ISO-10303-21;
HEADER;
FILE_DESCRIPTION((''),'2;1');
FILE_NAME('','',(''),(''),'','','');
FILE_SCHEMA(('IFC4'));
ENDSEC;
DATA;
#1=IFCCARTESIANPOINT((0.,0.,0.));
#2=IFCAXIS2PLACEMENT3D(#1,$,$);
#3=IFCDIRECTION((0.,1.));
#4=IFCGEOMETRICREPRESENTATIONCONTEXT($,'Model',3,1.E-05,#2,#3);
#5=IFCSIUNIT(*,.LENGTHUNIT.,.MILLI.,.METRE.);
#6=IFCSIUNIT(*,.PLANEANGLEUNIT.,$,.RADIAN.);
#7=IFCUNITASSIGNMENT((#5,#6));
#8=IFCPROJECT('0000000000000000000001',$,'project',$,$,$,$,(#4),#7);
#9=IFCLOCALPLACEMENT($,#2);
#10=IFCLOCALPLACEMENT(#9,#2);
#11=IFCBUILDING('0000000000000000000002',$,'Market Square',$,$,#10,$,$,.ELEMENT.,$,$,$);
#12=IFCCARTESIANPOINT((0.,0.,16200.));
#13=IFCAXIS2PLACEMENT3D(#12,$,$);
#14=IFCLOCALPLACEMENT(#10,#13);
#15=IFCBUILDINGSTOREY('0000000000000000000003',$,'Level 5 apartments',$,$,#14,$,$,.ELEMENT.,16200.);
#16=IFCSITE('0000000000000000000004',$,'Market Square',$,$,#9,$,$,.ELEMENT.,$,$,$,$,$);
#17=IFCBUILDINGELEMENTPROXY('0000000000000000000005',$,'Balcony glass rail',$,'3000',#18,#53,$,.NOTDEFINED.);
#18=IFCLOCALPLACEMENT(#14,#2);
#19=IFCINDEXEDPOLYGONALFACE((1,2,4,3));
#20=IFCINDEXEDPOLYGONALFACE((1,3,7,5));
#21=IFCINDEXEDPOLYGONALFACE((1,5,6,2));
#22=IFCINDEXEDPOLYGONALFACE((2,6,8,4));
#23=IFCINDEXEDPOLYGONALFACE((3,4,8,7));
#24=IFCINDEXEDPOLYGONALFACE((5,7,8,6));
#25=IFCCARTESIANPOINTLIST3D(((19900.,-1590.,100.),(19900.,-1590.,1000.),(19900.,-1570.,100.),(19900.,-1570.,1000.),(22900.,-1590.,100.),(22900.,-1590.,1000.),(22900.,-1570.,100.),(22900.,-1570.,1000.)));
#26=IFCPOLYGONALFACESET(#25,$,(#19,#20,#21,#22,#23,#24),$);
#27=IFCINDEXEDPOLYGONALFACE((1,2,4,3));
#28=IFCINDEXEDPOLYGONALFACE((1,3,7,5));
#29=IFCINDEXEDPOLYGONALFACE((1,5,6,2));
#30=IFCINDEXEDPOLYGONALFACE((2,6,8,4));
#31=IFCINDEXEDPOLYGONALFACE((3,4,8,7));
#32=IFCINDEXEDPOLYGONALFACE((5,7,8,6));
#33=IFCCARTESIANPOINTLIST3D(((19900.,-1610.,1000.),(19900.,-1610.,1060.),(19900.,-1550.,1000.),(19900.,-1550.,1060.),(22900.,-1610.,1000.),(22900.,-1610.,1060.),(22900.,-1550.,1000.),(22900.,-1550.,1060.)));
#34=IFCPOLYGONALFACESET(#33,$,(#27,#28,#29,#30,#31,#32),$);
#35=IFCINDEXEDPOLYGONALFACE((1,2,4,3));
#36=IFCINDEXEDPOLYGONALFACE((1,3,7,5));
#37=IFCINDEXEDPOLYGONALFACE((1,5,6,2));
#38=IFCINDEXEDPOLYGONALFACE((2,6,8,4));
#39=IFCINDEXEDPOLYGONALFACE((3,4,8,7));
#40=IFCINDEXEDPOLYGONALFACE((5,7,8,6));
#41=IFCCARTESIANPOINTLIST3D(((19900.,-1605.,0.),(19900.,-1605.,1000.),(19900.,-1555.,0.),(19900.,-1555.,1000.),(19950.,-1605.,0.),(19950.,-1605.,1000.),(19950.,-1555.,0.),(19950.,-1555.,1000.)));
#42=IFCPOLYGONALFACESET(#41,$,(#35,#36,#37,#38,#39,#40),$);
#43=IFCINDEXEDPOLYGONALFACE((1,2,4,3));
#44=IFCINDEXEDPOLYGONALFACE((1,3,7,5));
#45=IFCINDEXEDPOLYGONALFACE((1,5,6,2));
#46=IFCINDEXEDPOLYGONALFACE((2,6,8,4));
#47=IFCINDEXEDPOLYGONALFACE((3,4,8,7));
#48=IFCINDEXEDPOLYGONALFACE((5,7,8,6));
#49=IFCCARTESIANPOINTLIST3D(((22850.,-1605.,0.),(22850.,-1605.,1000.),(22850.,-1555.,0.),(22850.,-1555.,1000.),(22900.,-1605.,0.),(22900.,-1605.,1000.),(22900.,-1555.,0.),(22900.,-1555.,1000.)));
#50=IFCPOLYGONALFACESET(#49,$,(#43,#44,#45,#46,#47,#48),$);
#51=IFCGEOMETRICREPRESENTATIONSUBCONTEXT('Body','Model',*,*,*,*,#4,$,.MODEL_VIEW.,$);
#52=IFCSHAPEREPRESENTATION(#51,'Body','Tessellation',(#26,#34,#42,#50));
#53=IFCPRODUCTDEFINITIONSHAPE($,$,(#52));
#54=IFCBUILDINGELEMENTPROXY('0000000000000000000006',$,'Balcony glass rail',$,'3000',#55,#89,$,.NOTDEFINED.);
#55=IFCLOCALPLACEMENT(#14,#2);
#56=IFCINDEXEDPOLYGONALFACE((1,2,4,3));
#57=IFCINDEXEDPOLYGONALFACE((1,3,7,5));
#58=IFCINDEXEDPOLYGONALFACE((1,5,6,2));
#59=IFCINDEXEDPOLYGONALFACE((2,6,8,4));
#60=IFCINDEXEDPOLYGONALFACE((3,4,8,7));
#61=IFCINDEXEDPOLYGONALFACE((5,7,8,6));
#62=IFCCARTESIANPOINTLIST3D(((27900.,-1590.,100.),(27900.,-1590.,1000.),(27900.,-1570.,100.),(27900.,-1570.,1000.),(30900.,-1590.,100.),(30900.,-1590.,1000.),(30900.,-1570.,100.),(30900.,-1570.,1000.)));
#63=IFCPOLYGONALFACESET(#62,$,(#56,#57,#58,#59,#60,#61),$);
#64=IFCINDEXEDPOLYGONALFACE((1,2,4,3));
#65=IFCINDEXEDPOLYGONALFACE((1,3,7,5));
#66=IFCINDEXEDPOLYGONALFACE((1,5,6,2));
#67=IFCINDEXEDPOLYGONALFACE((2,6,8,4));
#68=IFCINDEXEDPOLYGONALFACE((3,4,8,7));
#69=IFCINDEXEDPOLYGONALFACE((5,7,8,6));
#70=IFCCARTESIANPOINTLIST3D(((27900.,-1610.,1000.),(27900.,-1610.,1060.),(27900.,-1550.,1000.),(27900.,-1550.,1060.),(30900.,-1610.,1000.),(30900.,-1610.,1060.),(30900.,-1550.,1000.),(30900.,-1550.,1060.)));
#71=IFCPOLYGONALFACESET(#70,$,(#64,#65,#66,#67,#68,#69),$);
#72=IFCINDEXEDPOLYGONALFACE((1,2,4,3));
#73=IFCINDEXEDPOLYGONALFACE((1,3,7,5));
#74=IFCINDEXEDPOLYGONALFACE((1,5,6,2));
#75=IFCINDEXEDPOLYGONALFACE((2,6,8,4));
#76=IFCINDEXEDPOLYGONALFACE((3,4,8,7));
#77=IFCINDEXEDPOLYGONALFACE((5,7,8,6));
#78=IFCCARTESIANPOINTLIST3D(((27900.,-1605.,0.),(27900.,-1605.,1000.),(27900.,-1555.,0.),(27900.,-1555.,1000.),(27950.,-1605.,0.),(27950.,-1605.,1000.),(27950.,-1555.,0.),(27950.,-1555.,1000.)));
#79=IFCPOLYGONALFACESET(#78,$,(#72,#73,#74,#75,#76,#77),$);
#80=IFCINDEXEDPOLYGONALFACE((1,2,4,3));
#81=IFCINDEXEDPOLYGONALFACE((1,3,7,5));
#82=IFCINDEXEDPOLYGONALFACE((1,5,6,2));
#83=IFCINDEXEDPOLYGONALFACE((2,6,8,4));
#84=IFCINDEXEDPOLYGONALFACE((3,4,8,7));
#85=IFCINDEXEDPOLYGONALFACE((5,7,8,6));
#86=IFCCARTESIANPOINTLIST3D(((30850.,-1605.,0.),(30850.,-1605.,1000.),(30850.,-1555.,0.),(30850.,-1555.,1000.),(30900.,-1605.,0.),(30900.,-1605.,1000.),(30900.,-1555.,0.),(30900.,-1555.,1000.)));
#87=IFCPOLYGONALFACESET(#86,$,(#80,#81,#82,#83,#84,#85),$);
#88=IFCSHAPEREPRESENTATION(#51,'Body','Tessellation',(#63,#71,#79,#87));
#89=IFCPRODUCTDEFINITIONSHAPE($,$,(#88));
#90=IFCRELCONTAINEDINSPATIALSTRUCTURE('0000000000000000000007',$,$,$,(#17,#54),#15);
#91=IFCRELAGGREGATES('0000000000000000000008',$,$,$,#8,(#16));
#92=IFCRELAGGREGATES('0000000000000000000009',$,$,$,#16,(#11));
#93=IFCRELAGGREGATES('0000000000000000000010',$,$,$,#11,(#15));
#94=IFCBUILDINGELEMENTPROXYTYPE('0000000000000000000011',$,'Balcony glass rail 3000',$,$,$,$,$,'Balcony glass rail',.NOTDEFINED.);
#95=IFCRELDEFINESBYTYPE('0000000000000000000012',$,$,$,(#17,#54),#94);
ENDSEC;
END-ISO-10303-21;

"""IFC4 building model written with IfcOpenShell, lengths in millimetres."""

from ifc_helpers import new_model, si_unit, direction, frame, origin, place, context, subcontext, project, spatial, polyline, outline, extrude, source, transform, mapped, type_object, type_shapes, element, save


model = new_model("IFC4")

# Units and contexts
model_context = context("Model", 3, precision=1e-05, world=origin(), true_north=direction((0.0, 1.0)))
body_context = subcontext(model_context, "Body", "Model", "MODEL_VIEW")
ifc_project = project(units=[si_unit("LENGTHUNIT", "METRE", prefix="MILLI"), si_unit("PLANEANGLEUNIT", "RADIAN")], contexts=[model_context])

# Site, building, storey
site_placement = place(None, origin())
site = spatial("IfcSite", under=ifc_project, at=site_placement, Name="Market Square", CompositionType="ELEMENT")
building_placement = place(site_placement, origin())
building = spatial("IfcBuilding", under=site, at=building_placement, Name="Market Square", CompositionType="ELEMENT")
storey_placement = place(building_placement, frame((0.0, 0.0, 16200.0)))
storey = spatial("IfcBuildingStorey", under=building, at=storey_placement, Name="Level 5 apartments", CompositionType="ELEMENT", Elevation=16200.0)

# Building element proxies
building_element_proxy_type = type_object("IfcBuildingElementProxyType", Name="Balcony glass rail 3000", ElementType="Balcony glass rail", PredefinedType="NOTDEFINED")
shared_shape = source(origin(), body_context, "Body", "SweptSolid", [
    extrude(outline(polyline([(0.0, -10.0), (3000.0, -10.0), (3000.0, 10.0), (0.0, 10.0), (0.0, -10.0)])), frame((0.0, 0.0, 100.0)), (0.0, 0.0, 1.0), 900.0),
    extrude(outline(polyline([(0.0, -30.0), (3000.0, -30.0), (3000.0, 30.0), (0.0, 30.0), (0.0, -30.0)])), frame((0.0, 0.0, 1000.0)), (0.0, 0.0, 1.0), 60.0),
    extrude(outline(polyline([(0.0, -25.0), (50.0, -25.0), (50.0, 25.0), (0.0, 25.0), (0.0, -25.0)])), origin(), (0.0, 0.0, 1.0), 1000.0),
    extrude(outline(polyline([(2950.0, -25.0), (3000.0, -25.0), (3000.0, 25.0), (2950.0, 25.0), (2950.0, -25.0)])), origin(), (0.0, 0.0, 1.0), 1000.0),
])
type_shapes(building_element_proxy_type, [shared_shape])
for number, where, z_axis, x_axis, name in (
    (1, (19900.0, -1580.0, 0.0), (0.0, 0.0, 1.0), (1.0, 0.0, 0.0), "Balcony glass rail"),
    (2, (27900.0, -1580.0, 0.0), (0.0, 0.0, 1.0), (1.0, 0.0, 0.0), "Balcony glass rail"),
):
    element("IfcBuildingElementProxy", number, at=place(storey_placement, frame(where, z_axis=z_axis, x_axis=x_axis)), inside=storey, type_object=building_element_proxy_type, Name=name, ObjectType="3000", PredefinedType="NOTDEFINED", context=body_context, shape_type="MappedRepresentation", body=[
        mapped(shared_shape, transform((0.0, 0.0, 0.0))),
    ])

save(model, "model.ifc")
